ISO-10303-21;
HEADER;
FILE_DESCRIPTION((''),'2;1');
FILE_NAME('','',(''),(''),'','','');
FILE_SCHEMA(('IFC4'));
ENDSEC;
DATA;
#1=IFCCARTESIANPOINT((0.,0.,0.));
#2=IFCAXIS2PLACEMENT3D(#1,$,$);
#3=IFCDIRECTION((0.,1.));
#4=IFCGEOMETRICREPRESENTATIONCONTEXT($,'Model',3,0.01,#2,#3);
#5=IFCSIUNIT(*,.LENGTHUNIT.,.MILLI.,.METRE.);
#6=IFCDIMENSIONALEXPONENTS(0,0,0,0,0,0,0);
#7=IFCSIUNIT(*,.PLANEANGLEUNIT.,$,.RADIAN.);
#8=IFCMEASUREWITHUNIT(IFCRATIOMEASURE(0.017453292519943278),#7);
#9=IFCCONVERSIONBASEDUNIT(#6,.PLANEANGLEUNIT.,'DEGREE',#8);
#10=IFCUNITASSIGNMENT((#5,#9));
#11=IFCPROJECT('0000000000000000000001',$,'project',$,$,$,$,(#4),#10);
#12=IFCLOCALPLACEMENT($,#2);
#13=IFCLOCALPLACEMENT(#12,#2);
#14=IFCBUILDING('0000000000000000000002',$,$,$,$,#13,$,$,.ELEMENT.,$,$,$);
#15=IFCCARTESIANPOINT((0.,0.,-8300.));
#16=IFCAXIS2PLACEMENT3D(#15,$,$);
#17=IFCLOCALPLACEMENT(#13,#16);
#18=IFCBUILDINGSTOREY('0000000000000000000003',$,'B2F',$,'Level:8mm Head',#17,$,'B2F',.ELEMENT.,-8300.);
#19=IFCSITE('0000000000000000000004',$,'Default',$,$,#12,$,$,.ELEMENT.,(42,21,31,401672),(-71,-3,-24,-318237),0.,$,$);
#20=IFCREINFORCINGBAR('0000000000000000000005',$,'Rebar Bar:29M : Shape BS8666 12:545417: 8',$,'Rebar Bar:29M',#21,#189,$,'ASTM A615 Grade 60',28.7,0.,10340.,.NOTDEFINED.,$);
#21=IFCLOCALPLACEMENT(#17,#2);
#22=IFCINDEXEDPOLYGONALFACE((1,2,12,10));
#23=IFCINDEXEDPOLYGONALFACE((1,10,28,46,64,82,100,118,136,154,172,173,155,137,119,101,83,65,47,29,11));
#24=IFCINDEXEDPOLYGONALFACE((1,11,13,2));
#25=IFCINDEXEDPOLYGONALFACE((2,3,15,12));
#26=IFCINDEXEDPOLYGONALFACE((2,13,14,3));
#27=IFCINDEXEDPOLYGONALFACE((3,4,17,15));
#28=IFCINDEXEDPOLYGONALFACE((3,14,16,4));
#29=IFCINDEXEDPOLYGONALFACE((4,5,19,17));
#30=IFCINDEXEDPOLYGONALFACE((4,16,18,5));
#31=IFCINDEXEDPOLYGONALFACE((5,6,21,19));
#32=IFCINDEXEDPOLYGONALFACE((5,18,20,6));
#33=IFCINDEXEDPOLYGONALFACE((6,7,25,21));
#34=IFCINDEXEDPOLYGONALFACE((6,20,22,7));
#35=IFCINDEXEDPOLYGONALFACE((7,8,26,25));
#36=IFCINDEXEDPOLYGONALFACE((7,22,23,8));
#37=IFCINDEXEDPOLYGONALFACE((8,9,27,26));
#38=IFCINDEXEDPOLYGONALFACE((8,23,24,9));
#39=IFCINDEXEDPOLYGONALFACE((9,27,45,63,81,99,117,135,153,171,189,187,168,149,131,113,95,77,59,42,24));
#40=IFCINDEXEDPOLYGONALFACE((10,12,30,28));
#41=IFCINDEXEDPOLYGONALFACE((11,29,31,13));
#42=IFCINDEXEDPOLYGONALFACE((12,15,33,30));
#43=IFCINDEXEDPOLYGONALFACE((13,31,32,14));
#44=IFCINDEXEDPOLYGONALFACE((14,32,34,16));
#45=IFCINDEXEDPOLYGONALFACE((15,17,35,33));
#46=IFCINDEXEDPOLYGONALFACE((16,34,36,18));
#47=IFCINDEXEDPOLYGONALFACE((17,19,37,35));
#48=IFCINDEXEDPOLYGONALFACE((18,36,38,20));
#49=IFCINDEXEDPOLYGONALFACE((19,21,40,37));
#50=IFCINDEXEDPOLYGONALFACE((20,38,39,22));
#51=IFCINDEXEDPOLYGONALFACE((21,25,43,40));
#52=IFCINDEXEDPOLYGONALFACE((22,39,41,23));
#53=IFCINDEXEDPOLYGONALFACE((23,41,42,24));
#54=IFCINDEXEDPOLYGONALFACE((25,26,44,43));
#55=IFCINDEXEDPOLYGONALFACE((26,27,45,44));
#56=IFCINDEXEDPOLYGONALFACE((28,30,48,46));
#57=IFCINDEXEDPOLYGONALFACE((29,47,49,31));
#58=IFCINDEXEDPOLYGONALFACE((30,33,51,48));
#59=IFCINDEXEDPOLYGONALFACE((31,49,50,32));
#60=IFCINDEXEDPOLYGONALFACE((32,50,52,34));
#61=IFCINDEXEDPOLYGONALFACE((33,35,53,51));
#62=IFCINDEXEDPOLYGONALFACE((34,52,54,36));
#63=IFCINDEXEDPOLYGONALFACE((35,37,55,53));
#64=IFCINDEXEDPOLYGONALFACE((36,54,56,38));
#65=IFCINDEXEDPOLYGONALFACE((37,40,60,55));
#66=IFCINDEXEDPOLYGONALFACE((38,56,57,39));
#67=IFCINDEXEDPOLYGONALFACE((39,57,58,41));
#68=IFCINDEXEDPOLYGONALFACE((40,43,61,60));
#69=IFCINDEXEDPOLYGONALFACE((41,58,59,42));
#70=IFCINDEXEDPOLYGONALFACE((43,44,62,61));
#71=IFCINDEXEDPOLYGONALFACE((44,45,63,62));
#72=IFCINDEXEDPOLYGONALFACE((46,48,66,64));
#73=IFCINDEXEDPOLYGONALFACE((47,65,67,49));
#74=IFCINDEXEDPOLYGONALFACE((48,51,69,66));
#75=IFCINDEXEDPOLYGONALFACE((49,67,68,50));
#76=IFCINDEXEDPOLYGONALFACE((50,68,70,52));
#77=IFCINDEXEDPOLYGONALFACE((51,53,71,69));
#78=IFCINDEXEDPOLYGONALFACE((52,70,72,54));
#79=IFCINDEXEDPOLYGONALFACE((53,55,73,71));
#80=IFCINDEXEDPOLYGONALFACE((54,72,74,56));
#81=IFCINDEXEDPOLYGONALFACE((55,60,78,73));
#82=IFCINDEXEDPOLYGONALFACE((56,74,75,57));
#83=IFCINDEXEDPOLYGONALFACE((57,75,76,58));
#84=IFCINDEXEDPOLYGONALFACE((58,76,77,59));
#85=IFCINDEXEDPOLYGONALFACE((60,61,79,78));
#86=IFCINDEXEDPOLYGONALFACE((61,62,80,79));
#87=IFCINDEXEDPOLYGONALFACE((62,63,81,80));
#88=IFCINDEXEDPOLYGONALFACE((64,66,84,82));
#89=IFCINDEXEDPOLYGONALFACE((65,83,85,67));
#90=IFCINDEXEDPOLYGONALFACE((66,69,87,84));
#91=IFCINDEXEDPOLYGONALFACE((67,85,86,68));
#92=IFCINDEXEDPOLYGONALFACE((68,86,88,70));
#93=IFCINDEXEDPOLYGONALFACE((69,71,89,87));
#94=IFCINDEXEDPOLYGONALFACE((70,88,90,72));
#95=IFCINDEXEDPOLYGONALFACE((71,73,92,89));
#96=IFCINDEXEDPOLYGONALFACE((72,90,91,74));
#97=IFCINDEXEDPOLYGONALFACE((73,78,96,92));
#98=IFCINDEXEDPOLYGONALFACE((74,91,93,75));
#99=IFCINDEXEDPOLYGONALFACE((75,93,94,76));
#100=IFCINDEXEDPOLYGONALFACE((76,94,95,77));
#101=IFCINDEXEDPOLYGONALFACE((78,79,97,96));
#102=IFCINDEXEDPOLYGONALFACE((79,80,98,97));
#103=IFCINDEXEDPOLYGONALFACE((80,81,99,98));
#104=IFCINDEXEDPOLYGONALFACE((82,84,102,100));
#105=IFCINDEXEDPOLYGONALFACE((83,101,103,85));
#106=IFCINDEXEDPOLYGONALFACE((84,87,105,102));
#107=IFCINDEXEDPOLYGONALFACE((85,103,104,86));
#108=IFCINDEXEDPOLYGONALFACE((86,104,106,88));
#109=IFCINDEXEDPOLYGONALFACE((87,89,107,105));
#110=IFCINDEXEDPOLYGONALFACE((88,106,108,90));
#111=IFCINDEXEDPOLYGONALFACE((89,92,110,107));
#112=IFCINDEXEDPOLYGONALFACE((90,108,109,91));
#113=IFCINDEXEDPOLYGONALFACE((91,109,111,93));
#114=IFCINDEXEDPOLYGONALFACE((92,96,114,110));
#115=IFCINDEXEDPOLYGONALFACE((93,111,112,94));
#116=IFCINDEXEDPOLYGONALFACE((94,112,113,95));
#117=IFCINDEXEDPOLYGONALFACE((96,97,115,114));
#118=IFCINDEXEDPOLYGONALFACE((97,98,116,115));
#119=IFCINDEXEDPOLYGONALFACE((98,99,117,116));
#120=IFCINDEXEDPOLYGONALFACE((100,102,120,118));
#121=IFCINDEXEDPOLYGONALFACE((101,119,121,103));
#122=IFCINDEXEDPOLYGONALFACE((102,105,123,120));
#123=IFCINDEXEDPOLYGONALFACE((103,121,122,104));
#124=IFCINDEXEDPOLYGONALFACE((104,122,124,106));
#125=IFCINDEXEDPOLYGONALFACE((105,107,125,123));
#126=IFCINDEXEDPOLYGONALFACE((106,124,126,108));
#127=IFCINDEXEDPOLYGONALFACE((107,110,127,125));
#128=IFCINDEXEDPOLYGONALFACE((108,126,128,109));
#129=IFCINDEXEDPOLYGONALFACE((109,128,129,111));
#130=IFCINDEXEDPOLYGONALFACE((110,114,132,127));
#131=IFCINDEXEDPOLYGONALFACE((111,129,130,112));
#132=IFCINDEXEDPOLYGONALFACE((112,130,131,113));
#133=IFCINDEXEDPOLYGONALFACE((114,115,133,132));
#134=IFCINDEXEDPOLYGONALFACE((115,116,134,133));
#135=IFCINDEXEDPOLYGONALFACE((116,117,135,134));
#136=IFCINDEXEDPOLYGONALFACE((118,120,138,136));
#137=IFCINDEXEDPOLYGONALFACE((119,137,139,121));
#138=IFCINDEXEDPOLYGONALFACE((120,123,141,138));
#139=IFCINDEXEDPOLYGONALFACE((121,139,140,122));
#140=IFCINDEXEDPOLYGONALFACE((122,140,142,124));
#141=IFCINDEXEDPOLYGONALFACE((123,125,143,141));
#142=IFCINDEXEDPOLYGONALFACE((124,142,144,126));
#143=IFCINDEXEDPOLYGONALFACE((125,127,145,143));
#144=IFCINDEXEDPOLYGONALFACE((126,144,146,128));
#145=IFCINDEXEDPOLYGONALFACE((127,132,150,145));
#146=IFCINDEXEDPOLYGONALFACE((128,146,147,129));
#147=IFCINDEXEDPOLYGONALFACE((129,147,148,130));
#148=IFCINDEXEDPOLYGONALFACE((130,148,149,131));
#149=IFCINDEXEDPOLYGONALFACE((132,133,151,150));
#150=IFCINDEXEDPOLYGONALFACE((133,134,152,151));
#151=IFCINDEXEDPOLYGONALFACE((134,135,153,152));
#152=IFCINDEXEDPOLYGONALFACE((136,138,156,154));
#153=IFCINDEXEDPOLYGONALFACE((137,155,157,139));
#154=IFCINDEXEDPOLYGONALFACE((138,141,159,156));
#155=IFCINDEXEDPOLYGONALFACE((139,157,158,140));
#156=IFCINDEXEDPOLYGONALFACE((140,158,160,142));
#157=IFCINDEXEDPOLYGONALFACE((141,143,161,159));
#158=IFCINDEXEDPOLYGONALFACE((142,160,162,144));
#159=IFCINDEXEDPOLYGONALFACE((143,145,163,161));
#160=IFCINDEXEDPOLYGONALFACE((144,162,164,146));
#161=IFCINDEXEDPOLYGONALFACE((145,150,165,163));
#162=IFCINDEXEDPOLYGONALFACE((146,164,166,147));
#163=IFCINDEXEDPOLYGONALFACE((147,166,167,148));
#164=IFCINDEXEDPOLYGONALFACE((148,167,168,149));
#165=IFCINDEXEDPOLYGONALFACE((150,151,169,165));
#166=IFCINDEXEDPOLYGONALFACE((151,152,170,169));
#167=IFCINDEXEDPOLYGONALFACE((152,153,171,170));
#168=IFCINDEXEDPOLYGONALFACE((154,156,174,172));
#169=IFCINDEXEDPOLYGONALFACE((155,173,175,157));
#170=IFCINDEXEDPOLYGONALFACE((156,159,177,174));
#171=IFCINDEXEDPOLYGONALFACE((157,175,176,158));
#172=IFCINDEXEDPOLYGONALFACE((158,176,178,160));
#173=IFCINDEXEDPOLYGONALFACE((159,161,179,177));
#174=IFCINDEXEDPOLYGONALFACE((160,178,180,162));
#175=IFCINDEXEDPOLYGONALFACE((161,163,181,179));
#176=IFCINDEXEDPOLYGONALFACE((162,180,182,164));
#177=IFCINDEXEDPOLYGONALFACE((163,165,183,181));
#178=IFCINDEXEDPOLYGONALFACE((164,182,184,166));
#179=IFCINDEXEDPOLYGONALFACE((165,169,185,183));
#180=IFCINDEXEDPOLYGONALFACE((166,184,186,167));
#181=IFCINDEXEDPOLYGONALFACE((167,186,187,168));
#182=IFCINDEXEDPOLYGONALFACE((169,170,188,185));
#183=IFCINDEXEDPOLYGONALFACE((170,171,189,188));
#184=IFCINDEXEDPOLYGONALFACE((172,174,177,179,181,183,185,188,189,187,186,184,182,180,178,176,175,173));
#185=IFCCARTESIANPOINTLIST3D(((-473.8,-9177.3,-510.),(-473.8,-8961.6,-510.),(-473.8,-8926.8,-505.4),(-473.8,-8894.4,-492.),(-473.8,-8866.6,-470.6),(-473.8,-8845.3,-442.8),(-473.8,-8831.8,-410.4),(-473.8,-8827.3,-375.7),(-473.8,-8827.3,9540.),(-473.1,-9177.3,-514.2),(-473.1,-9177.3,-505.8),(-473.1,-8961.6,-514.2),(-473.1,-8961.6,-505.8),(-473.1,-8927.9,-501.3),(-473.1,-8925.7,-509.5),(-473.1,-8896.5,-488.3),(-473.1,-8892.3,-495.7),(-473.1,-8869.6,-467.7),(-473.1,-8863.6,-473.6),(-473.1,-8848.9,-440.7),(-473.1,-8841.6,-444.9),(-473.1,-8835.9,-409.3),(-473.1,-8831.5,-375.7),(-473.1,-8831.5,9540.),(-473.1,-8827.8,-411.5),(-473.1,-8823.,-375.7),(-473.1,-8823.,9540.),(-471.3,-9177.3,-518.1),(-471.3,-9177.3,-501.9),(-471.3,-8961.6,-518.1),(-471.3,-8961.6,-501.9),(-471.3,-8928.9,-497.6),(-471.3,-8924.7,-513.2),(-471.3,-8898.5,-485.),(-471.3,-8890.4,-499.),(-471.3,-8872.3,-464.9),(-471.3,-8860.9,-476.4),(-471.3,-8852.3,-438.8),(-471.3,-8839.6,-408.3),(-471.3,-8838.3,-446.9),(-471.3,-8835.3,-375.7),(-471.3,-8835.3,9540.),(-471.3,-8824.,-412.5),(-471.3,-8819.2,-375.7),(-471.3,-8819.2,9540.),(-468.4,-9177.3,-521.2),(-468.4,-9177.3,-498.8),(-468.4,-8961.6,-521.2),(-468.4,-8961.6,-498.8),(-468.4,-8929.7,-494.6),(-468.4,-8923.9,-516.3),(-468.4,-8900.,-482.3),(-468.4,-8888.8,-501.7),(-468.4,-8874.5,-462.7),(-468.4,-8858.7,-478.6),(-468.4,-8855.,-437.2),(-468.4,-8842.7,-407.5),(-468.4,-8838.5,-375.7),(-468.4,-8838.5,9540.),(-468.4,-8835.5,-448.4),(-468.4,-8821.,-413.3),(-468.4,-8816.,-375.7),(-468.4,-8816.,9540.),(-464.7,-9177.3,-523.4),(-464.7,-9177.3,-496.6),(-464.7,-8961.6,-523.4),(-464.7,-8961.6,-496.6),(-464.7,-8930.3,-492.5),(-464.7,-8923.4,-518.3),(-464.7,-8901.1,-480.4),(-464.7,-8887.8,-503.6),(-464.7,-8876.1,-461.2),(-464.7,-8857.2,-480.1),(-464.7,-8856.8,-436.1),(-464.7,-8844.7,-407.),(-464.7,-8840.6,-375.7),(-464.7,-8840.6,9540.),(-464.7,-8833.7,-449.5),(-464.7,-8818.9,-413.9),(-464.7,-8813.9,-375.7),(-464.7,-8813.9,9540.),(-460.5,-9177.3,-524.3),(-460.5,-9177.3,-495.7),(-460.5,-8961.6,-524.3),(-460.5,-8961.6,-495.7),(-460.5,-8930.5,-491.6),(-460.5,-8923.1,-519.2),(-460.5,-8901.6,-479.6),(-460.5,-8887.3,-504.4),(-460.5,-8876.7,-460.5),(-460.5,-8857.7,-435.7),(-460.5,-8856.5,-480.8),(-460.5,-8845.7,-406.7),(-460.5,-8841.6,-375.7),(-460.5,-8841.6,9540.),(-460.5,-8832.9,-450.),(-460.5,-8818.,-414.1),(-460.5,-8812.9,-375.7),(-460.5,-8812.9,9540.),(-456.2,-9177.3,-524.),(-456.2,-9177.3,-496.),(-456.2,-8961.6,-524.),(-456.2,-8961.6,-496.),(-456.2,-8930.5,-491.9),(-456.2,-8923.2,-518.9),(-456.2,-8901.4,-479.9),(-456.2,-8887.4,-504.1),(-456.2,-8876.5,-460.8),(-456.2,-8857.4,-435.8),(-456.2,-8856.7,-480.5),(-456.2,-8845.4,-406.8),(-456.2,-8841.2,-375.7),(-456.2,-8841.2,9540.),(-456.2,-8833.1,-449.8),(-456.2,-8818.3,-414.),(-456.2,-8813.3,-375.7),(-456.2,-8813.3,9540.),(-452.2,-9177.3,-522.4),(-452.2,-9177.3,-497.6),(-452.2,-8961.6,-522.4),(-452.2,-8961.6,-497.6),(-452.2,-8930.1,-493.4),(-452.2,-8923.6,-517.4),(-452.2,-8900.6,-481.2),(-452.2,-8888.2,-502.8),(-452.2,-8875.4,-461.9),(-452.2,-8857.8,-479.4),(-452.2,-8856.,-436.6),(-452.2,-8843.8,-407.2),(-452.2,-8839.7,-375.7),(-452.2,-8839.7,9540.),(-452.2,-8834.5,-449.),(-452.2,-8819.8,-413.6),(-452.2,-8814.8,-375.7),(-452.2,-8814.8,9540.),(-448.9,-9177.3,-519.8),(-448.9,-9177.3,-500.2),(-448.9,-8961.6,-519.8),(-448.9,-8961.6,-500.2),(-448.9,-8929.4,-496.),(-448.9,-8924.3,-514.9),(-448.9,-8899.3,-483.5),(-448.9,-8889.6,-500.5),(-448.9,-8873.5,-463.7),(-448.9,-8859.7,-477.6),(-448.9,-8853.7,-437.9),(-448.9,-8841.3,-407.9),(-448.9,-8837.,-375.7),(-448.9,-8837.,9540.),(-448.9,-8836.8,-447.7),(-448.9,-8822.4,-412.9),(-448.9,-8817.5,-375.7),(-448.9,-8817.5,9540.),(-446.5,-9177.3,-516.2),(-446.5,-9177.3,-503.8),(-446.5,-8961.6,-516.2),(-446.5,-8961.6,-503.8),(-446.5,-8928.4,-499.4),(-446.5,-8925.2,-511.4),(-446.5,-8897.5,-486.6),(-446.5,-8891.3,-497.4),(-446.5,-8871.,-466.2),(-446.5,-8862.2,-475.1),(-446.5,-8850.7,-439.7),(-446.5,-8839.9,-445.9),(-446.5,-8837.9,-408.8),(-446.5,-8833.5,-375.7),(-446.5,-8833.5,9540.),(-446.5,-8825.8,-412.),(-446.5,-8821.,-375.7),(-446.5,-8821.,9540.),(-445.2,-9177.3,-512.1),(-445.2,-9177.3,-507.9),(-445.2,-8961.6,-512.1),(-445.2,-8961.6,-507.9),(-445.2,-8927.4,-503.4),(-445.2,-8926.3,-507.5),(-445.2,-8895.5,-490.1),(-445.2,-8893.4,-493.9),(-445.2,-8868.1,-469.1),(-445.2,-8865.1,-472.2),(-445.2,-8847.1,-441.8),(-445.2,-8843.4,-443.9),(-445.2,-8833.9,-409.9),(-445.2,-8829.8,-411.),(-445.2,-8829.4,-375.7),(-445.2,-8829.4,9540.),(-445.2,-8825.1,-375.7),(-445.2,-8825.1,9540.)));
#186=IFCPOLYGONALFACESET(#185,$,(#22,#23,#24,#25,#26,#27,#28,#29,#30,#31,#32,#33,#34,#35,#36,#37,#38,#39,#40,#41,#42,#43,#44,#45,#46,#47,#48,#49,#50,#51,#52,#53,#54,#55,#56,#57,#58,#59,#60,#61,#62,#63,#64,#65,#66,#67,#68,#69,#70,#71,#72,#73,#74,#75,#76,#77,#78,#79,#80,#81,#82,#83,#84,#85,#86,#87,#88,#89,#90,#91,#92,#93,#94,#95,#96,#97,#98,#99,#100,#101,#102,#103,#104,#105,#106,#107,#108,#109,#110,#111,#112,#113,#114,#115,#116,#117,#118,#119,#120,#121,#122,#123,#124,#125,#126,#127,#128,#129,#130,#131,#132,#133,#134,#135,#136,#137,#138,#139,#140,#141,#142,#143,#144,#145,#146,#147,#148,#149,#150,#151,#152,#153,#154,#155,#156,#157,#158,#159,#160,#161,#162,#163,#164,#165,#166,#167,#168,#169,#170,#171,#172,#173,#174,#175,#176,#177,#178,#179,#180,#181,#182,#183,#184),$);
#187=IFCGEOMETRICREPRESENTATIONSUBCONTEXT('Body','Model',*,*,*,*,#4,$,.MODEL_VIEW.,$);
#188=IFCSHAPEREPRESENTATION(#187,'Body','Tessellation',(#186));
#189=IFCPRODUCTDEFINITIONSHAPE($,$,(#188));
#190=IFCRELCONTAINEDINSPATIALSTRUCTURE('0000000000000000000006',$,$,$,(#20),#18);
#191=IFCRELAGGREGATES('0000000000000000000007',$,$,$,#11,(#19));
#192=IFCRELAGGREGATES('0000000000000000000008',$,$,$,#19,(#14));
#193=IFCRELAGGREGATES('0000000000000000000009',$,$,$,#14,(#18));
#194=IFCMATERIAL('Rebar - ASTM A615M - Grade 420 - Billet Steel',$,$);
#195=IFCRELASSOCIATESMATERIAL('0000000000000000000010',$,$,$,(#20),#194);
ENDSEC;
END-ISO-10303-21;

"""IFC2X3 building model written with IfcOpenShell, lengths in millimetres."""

from ifc_helpers import new_model, entity, si_unit, converted_unit, direction, frame, origin, place, context, subcontext, project, spatial, material, element, save


model = new_model("IFC2X3")

# Units and contexts
model_context = context("Model", 3, precision=0.01, world=origin(), true_north=direction((0.0, 1.0)))
body_context = subcontext(model_context, "Body", "Model", "MODEL_VIEW")
ifc_project = project(units=[si_unit("LENGTHUNIT", "METRE", prefix="MILLI"), converted_unit("PLANEANGLEUNIT", "DEGREE", entity("IfcRatioMeasure", 0.017453292519943278), si_unit("PLANEANGLEUNIT", "RADIAN"), dimensions=[0, 0, 0, 0, 0, 0, 0])], contexts=[model_context])

# Site, building, storey
site_placement = place(None, origin())
site = spatial("IfcSite", under=ifc_project, at=site_placement, Name="Default", CompositionType="ELEMENT", RefLatitude=(42, 21, 31, 401672), RefLongitude=(-71, -3, -24, -318237), RefElevation=0.0)
building_placement = place(site_placement, origin())
building = spatial("IfcBuilding", under=site, at=building_placement, CompositionType="ELEMENT")
storey_placement = place(building_placement, frame((0.0, 0.0, -8300.0)))
storey = spatial("IfcBuildingStorey", under=building, at=storey_placement, Name="B2F", ObjectType="Level:8mm Head", LongName="B2F", CompositionType="ELEMENT", Elevation=-8300.0)

# Reinforcing bar
ifc_material_1 = material(Name="Rebar - ASTM A615M - Grade 420 - Billet Steel")
reinforcing_bar_1_placement = place(storey_placement, origin())
element("IfcReinforcingBar", 1, at=reinforcing_bar_1_placement, inside=storey, material=ifc_material_1, Name="Rebar Bar:29M : Shape BS8666 12:545417: 8", SteelGrade="ASTM A615 Grade 60", ObjectType="Rebar Bar:29M", BarLength=10340.0, BarRole="NOTDEFINED", CrossSectionArea=0.0, NominalDiameter=28.7, context=body_context, shape_type="AdvancedSweptSolid", body=[
    entity("IfcSweptDiskSolid", entity("IfcCompositeCurve", [entity("IfcCompositeCurveSegment", "CONTINUOUS", True, entity("IfcPolyline", [entity("IfcCartesianPoint", [-459.4, -8827.3, 9540.0]), entity("IfcCartesianPoint", [-459.4, -8827.3, -375.7])])), entity("IfcCompositeCurveSegment", "CONTINUOUS", True, entity("IfcTrimmedCurve", entity("IfcCircle", entity("IfcAxis2Placement3D", entity("IfcCartesianPoint", [-459.4, -8961.6, -375.7]), entity("IfcDirection", [-1.0, 0.0, 0.0]), entity("IfcDirection", [0.0, 0.0, -1.0])), 134.3), [entity("IfcParameterValue", 270.0)], [entity("IfcParameterValue", 360.0)], True, "PARAMETER")), entity("IfcCompositeCurveSegment", "CONTINUOUS", True, entity("IfcPolyline", [entity("IfcCartesianPoint", [-459.4, -8961.6, -510.0]), entity("IfcCartesianPoint", [-459.4, -9177.3, -510.0])]))], False), 14.3, None, 0.0, 92.0),
])

save(model, "model.ifc")
